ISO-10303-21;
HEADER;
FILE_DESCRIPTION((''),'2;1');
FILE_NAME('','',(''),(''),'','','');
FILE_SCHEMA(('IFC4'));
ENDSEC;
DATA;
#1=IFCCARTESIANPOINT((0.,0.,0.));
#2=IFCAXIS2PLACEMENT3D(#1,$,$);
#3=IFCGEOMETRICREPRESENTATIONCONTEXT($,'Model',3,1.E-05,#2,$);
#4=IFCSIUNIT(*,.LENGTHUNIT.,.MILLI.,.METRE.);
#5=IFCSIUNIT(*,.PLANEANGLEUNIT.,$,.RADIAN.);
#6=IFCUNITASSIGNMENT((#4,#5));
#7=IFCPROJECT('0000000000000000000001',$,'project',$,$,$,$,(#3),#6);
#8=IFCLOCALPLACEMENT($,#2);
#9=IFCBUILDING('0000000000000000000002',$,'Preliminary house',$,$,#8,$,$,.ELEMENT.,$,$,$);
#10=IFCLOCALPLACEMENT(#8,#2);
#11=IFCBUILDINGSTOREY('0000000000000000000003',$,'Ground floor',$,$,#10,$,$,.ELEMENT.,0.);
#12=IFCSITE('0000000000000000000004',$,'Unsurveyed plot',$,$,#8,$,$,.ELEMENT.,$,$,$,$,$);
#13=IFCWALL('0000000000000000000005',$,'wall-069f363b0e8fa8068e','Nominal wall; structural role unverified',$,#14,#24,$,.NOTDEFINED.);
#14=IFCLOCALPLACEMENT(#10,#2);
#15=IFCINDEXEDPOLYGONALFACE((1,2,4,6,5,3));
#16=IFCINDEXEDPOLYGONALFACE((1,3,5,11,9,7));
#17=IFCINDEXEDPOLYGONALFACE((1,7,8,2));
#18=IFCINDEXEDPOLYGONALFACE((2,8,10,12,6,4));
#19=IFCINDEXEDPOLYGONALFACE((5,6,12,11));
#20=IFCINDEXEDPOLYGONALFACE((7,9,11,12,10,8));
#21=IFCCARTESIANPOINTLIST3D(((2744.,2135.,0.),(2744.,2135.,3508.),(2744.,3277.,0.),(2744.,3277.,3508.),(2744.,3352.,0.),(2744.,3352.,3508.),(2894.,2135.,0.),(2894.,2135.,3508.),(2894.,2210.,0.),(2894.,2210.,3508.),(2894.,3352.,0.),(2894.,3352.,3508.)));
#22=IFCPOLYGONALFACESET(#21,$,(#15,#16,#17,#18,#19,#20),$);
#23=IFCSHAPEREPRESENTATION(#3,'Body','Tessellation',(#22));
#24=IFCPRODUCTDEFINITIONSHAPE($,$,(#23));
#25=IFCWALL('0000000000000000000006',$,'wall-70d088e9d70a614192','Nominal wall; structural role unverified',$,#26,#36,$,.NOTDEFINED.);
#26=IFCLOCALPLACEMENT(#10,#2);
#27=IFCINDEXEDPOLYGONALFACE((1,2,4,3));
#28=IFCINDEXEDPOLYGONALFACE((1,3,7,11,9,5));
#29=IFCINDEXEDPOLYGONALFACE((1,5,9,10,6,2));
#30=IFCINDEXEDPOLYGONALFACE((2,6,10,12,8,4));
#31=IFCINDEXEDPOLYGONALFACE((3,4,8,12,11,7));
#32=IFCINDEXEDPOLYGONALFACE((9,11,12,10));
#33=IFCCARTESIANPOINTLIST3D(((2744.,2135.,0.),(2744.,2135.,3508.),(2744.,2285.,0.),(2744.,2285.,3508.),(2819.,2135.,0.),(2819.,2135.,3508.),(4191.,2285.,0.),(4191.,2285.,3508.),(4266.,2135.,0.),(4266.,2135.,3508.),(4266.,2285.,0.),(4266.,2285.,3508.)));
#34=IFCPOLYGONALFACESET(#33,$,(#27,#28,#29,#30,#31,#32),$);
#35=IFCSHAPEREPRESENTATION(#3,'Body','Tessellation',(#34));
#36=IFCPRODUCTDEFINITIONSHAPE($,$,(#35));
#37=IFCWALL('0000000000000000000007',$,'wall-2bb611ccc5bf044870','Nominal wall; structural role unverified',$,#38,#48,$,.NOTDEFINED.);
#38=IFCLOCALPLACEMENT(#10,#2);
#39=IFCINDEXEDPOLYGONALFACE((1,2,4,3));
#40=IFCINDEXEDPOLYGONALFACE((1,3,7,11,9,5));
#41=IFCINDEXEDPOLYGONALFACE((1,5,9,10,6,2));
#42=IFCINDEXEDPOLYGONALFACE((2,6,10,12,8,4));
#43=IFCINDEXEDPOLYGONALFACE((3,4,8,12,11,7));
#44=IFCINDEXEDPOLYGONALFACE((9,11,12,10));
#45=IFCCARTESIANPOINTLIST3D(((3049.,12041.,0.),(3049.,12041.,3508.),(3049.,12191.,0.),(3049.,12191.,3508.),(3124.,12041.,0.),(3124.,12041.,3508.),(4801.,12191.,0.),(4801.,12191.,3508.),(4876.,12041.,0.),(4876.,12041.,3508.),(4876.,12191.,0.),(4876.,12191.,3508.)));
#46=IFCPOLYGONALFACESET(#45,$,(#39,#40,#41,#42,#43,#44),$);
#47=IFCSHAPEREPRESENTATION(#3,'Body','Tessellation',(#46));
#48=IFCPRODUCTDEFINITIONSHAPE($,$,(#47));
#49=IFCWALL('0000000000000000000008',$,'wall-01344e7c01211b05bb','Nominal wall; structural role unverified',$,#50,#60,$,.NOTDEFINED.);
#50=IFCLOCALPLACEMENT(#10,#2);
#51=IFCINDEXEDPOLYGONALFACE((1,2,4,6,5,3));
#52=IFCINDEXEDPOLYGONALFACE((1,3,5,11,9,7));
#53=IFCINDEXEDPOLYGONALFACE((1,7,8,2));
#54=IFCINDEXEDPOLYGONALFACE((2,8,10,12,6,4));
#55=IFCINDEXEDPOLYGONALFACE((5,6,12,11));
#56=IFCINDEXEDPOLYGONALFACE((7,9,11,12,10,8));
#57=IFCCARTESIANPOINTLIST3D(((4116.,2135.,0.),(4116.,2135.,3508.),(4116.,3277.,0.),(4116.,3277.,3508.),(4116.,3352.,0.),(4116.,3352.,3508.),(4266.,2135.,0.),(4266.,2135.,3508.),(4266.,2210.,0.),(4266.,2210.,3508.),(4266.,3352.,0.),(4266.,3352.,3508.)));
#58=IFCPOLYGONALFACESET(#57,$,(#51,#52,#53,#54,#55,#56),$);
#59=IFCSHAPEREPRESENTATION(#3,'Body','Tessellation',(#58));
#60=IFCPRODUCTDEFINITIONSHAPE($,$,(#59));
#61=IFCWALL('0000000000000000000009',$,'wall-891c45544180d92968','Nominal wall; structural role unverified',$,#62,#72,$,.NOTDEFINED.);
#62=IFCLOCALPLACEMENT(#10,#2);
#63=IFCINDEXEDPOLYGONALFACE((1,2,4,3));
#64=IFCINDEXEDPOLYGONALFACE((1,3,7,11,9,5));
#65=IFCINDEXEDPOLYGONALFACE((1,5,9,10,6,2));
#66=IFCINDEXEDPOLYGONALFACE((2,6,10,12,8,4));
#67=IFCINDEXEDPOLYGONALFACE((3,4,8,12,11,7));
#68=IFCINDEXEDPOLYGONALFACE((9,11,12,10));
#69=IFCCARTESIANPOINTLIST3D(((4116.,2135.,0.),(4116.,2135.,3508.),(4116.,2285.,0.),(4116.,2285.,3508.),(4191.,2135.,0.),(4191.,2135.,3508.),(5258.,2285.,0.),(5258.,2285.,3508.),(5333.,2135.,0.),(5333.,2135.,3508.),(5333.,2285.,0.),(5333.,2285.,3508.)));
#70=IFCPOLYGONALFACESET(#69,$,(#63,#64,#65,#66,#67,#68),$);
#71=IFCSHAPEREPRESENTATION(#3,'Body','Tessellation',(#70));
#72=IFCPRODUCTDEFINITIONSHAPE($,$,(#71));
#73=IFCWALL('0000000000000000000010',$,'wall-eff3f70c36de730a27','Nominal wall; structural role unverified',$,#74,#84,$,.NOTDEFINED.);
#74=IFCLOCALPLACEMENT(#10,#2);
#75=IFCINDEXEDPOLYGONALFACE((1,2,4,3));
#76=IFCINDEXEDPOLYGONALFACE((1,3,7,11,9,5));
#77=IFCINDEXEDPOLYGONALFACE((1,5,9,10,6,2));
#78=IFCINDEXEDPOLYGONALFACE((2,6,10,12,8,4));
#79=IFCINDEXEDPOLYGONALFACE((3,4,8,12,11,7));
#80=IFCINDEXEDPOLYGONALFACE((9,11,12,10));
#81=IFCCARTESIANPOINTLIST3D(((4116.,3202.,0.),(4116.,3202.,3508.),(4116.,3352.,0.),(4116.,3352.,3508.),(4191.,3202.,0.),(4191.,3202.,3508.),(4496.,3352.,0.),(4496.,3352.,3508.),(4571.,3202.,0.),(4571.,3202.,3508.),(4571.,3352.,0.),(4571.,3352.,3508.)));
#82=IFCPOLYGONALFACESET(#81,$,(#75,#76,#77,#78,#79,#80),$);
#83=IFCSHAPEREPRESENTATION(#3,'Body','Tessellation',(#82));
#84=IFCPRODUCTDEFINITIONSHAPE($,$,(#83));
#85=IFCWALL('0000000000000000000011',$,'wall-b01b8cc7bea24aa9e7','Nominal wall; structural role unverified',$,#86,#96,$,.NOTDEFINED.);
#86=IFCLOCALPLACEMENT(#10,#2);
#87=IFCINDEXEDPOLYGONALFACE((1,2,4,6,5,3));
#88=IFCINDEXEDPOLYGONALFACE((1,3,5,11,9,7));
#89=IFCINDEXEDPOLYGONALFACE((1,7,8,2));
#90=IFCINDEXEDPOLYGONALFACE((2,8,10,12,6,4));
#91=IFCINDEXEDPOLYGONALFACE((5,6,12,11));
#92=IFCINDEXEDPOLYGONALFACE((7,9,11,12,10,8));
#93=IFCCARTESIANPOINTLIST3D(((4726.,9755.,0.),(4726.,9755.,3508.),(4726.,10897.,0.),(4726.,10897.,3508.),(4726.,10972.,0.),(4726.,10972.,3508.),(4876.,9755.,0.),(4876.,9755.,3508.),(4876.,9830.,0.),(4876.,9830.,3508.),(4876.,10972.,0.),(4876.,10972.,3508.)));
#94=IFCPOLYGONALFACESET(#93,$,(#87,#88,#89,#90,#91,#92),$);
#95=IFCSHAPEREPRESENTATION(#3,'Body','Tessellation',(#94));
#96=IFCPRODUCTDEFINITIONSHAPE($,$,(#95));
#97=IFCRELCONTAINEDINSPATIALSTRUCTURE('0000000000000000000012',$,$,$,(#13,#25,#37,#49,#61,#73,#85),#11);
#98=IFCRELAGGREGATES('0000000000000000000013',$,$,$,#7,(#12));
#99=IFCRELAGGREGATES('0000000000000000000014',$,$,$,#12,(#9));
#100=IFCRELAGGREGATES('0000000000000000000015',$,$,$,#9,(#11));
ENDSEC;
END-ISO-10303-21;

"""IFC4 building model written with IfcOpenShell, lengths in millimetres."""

from ifc_helpers import new_model, si_unit, origin, place, context, project, spatial, polyline, outline, extrude, element, save


model = new_model("IFC4")

# Units and contexts
model_context = context("Model", 3, precision=1e-05, world=origin())
ifc_project = project(units=[si_unit("LENGTHUNIT", "METRE", prefix="MILLI"), si_unit("PLANEANGLEUNIT", "RADIAN")], contexts=[model_context])

# Site, building, storey
placement_1 = place(None, origin())
site = spatial("IfcSite", under=ifc_project, at=placement_1, Name="Unsurveyed plot", CompositionType="ELEMENT")
building = spatial("IfcBuilding", under=site, at=placement_1, Name="Preliminary house", CompositionType="ELEMENT")
placement_2 = place(placement_1, origin())
storey = spatial("IfcBuildingStorey", under=building, at=placement_2, Name="Ground floor", CompositionType="ELEMENT", Elevation=0.0)

# Walls
element("IfcWall", 1, at=placement_2, inside=storey, Name="wall-069f363b0e8fa8068e", Description="Nominal wall; structural role unverified", PredefinedType="NOTDEFINED", context=model_context, shape_type="SweptSolid", body=[
    extrude(outline(polyline([(2744.0, 3277.0), (2744.0, 3352.0), (2894.0, 3352.0), (2894.0, 2210.0), (2894.0, 2135.0), (2744.0, 2135.0), (2744.0, 3277.0)])), origin(), (0.0, 0.0, 1.0), 3508.0),
])
element("IfcWall", 2, at=placement_2, inside=storey, Name="wall-70d088e9d70a614192", Description="Nominal wall; structural role unverified", PredefinedType="NOTDEFINED", context=model_context, shape_type="SweptSolid", body=[
    extrude(outline(polyline([(4191.0, 2285.0), (4266.0, 2285.0), (4266.0, 2135.0), (2819.0, 2135.0), (2744.0, 2135.0), (2744.0, 2285.0), (4191.0, 2285.0)])), origin(), (0.0, 0.0, 1.0), 3508.0),
])

# Wall
element("IfcWall", 3, at=placement_2, inside=storey, Name="wall-2bb611ccc5bf044870", Description="Nominal wall; structural role unverified", PredefinedType="NOTDEFINED", context=model_context, shape_type="SweptSolid", body=[
    extrude(outline(polyline([(4801.0, 12191.0), (4876.0, 12191.0), (4876.0, 12041.0), (3124.0, 12041.0), (3049.0, 12041.0), (3049.0, 12191.0), (4801.0, 12191.0)])), origin(), (0.0, 0.0, 1.0), 3508.0),
])

# Walls
element("IfcWall", 4, at=placement_2, inside=storey, Name="wall-01344e7c01211b05bb", Description="Nominal wall; structural role unverified", PredefinedType="NOTDEFINED", context=model_context, shape_type="SweptSolid", body=[
    extrude(outline(polyline([(4116.0, 3277.0), (4116.0, 3352.0), (4266.0, 3352.0), (4266.0, 2210.0), (4266.0, 2135.0), (4116.0, 2135.0), (4116.0, 3277.0)])), origin(), (0.0, 0.0, 1.0), 3508.0),
])
element("IfcWall", 5, at=placement_2, inside=storey, Name="wall-891c45544180d92968", Description="Nominal wall; structural role unverified", PredefinedType="NOTDEFINED", context=model_context, shape_type="SweptSolid", body=[
    extrude(outline(polyline([(5258.0, 2285.0), (5333.0, 2285.0), (5333.0, 2135.0), (4191.0, 2135.0), (4116.0, 2135.0), (4116.0, 2285.0), (5258.0, 2285.0)])), origin(), (0.0, 0.0, 1.0), 3508.0),
])
element("IfcWall", 6, at=placement_2, inside=storey, Name="wall-eff3f70c36de730a27", Description="Nominal wall; structural role unverified", PredefinedType="NOTDEFINED", context=model_context, shape_type="SweptSolid", body=[
    extrude(outline(polyline([(4496.0, 3352.0), (4571.0, 3352.0), (4571.0, 3202.0), (4191.0, 3202.0), (4116.0, 3202.0), (4116.0, 3352.0), (4496.0, 3352.0)])), origin(), (0.0, 0.0, 1.0), 3508.0),
])

# Wall
element("IfcWall", 7, at=placement_2, inside=storey, Name="wall-b01b8cc7bea24aa9e7", Description="Nominal wall; structural role unverified", PredefinedType="NOTDEFINED", context=model_context, shape_type="SweptSolid", body=[
    extrude(outline(polyline([(4726.0, 10897.0), (4726.0, 10972.0), (4876.0, 10972.0), (4876.0, 9830.0), (4876.0, 9755.0), (4726.0, 9755.0), (4726.0, 10897.0)])), origin(), (0.0, 0.0, 1.0), 3508.0),
])

save(model, "model.ifc")
